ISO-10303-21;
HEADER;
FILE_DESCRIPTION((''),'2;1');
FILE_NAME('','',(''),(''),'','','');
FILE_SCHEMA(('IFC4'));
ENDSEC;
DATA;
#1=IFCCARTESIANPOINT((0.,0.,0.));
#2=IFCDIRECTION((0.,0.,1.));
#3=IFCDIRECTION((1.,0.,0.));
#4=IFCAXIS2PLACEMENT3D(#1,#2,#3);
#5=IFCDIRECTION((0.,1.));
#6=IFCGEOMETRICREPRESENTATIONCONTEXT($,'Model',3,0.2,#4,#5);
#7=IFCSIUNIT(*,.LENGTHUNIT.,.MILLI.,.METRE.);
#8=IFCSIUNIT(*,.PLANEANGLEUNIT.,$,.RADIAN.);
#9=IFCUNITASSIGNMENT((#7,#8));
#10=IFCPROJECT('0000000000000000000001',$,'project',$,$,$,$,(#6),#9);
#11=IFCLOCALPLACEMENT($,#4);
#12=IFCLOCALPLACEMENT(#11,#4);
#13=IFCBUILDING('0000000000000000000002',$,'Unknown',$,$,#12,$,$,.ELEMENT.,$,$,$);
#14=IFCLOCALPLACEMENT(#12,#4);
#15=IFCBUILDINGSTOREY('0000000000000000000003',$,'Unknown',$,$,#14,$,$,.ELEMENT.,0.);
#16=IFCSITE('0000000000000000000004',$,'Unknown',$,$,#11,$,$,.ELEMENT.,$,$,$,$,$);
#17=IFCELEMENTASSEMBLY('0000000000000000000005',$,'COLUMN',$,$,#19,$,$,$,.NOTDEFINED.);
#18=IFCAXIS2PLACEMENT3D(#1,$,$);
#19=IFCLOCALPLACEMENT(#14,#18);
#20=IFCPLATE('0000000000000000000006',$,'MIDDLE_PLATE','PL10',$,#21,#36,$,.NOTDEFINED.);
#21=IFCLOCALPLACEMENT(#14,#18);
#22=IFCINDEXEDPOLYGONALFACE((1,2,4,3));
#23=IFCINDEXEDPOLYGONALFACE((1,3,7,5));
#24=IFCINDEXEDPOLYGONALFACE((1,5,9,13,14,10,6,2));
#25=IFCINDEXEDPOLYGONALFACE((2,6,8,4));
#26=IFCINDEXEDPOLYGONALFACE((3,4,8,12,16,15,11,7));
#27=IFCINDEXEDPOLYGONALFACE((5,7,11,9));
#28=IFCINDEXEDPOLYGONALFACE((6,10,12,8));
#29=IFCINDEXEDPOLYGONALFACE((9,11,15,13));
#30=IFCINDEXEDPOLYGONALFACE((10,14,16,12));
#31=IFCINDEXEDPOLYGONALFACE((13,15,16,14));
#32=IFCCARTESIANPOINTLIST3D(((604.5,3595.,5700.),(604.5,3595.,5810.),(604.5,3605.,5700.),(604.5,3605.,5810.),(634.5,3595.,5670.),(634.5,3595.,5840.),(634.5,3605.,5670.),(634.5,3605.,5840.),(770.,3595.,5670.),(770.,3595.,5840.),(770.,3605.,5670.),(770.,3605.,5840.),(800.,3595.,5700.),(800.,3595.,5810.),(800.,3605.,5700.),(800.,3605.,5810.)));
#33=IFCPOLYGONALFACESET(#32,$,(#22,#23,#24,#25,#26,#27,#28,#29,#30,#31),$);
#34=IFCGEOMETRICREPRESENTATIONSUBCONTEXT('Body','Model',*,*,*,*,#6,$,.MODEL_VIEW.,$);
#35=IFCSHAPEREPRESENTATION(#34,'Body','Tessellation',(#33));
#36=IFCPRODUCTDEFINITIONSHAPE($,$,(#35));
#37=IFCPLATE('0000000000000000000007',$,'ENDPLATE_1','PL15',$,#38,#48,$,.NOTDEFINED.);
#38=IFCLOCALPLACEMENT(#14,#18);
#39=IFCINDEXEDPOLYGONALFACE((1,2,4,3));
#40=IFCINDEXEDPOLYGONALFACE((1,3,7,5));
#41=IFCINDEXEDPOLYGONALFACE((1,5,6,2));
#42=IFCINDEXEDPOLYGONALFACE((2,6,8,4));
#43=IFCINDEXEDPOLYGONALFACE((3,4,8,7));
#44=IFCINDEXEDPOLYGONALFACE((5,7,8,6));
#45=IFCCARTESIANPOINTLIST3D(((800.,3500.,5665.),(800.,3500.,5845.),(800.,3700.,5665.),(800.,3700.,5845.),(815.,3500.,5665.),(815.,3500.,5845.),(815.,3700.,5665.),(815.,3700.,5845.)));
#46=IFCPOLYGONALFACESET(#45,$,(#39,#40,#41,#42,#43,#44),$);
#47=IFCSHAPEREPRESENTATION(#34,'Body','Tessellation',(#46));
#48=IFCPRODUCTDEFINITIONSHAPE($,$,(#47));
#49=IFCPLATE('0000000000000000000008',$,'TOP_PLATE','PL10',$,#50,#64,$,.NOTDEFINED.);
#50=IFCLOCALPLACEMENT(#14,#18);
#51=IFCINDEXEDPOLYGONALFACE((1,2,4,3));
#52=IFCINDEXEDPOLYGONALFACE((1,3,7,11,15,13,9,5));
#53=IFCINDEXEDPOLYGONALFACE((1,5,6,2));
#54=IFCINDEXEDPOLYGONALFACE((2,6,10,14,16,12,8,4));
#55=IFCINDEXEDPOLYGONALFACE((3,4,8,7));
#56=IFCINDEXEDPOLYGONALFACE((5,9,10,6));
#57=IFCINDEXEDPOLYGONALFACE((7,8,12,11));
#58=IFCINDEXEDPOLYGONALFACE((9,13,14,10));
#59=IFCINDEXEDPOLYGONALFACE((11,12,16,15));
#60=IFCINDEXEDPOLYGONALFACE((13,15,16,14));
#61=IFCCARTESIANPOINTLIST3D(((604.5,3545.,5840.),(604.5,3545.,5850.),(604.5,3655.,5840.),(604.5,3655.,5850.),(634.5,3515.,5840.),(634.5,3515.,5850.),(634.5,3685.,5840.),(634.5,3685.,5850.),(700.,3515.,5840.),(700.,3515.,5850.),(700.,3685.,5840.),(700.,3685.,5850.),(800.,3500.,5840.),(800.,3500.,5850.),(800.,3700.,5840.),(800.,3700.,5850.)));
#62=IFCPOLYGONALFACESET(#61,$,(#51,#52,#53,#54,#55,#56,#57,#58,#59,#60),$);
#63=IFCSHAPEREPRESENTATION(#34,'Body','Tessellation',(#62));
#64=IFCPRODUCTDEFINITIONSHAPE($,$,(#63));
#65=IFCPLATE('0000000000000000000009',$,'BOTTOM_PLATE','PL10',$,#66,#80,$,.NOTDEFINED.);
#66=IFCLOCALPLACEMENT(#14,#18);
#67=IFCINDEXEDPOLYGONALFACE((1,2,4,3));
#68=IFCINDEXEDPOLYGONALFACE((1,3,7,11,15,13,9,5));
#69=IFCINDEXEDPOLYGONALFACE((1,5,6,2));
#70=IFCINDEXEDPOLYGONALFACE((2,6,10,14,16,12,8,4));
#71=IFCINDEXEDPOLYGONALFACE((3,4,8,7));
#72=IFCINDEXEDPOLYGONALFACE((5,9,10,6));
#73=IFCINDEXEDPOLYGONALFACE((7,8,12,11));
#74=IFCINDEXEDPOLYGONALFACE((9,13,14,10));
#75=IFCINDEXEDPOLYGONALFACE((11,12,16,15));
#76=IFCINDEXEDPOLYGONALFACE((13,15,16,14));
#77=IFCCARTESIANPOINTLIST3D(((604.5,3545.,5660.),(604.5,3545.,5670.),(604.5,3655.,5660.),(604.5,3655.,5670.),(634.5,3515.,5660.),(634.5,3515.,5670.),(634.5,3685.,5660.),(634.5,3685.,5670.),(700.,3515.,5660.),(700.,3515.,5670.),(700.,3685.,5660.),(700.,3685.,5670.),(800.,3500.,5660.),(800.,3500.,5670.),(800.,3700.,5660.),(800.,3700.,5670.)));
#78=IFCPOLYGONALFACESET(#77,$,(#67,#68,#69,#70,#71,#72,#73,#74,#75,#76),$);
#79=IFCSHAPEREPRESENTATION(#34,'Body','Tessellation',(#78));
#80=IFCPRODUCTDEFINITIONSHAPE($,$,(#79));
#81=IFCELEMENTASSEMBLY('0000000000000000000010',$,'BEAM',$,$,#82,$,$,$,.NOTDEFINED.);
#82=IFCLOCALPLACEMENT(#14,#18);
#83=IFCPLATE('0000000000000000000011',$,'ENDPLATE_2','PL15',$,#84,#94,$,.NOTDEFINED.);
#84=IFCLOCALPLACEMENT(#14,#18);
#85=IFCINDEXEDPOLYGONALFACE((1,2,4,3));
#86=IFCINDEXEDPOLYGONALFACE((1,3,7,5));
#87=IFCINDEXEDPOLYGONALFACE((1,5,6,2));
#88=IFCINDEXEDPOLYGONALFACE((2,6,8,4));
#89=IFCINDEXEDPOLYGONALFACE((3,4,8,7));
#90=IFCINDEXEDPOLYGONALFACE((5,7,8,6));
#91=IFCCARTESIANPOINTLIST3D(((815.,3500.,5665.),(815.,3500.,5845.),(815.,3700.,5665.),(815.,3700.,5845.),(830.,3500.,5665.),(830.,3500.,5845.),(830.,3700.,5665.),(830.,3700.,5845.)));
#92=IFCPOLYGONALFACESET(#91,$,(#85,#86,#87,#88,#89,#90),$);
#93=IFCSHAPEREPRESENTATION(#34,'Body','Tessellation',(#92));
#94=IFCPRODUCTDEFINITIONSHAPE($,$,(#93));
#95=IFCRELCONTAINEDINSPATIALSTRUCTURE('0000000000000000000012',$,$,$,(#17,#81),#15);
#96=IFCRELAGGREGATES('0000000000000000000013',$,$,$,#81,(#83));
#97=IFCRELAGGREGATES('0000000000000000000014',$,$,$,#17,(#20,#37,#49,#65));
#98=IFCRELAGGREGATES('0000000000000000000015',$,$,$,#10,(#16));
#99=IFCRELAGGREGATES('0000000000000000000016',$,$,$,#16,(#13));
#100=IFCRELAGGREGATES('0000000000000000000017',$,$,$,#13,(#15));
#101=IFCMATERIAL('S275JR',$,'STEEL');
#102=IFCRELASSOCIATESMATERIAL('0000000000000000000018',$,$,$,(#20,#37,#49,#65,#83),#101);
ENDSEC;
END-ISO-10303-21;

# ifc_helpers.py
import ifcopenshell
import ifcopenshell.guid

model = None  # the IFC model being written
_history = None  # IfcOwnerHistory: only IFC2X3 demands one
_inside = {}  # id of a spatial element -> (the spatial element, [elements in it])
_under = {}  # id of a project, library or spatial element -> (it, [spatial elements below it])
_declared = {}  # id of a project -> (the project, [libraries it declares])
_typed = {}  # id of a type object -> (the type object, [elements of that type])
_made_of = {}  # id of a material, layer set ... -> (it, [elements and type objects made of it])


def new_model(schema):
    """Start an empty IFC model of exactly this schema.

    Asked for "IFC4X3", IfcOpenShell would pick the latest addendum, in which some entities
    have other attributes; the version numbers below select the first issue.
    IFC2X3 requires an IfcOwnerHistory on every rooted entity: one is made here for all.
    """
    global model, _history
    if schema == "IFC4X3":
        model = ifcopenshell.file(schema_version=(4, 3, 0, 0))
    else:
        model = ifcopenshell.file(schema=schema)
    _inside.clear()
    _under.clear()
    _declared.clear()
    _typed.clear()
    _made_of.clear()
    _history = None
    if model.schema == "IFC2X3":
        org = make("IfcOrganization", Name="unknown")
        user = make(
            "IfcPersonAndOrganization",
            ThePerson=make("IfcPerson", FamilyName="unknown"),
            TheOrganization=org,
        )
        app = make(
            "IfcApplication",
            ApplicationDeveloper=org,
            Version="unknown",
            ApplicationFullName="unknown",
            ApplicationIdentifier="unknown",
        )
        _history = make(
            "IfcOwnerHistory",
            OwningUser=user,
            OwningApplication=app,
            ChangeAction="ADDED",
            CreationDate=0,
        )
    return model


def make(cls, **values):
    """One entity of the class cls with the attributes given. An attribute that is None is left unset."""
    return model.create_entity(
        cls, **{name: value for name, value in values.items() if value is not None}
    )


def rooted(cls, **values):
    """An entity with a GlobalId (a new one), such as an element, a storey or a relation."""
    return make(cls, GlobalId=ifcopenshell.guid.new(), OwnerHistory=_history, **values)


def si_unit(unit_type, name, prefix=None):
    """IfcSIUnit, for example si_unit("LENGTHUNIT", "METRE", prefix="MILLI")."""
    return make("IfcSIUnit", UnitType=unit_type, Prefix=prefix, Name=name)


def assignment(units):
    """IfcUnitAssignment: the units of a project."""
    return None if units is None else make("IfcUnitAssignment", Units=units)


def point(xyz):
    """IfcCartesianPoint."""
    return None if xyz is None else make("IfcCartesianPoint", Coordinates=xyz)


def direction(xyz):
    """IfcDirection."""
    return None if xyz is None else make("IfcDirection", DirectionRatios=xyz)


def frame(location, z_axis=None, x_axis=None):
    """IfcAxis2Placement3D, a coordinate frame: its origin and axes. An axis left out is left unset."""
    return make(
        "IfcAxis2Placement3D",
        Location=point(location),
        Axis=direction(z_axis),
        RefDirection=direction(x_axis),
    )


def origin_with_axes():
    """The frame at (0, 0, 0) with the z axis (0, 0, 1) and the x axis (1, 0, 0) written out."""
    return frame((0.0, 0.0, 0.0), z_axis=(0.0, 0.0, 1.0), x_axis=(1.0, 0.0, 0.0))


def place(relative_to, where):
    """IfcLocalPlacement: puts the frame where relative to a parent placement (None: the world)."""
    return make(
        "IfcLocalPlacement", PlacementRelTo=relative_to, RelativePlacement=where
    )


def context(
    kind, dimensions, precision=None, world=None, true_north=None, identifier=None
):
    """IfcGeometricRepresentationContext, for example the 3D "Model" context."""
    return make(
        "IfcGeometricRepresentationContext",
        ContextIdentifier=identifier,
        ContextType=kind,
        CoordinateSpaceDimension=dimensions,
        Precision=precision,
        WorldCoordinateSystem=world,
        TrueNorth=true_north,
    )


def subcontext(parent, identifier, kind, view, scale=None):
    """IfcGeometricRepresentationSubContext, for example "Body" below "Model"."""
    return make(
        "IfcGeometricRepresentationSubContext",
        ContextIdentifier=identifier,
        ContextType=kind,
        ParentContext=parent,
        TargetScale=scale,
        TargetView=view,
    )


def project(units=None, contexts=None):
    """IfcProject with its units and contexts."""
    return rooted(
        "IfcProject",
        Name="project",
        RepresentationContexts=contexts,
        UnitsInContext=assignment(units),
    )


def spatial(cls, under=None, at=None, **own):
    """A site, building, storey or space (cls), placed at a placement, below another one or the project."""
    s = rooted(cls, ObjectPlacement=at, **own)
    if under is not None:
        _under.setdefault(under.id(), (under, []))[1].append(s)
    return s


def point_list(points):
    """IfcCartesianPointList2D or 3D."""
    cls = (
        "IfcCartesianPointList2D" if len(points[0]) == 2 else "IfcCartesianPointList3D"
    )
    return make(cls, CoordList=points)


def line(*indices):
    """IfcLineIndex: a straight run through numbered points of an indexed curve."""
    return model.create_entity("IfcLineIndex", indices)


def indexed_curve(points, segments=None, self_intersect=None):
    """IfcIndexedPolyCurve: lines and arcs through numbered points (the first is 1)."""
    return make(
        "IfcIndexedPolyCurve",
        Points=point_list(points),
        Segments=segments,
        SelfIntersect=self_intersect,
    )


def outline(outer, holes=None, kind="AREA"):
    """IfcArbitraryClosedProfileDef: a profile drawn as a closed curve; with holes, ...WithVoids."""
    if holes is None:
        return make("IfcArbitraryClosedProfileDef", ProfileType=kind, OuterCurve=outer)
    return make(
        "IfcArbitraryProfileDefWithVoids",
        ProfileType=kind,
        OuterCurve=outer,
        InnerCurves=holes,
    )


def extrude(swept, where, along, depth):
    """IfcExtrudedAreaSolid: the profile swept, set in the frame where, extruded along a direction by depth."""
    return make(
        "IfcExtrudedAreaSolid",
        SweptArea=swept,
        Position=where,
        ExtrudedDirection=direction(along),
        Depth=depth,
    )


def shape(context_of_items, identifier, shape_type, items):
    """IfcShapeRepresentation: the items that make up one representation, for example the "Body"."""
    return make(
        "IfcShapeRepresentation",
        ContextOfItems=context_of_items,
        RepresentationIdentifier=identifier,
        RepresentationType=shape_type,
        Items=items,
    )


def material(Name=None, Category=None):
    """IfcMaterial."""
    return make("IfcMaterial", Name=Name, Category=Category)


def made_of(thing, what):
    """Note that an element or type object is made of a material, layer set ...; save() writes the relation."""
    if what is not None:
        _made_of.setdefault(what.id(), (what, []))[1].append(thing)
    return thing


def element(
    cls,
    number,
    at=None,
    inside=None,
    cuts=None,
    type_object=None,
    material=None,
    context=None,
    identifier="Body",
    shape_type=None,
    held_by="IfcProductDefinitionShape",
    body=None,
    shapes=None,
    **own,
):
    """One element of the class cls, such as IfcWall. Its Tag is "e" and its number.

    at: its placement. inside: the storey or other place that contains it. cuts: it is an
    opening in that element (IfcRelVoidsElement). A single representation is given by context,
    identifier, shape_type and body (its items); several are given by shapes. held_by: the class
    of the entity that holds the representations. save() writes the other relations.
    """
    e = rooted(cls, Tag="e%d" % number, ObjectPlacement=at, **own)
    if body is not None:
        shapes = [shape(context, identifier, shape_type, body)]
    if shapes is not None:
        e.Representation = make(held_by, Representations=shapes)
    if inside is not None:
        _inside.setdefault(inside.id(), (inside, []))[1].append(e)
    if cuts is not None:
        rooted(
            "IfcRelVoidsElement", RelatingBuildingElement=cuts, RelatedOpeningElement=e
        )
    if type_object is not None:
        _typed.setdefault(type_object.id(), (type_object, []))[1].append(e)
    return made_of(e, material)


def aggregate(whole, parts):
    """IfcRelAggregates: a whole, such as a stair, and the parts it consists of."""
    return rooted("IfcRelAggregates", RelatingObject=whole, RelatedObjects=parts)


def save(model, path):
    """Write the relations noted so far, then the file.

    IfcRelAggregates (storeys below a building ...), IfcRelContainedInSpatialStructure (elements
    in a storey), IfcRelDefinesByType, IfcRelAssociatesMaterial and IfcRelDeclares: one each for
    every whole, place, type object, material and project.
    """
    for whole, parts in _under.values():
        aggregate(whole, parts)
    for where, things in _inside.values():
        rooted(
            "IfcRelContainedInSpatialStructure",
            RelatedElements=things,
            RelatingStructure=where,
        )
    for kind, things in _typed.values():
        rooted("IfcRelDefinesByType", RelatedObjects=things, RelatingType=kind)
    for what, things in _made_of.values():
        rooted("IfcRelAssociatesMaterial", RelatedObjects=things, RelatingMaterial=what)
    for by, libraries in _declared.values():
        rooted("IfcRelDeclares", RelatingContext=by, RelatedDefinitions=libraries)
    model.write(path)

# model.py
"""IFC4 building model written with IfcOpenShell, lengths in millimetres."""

from ifc_helpers import new_model, si_unit, direction, frame, origin_with_axes, place, context, subcontext, project, spatial, line, indexed_curve, outline, extrude, material, element, aggregate, save


model = new_model("IFC4")

# Units and contexts
model_context = context("Model", 3, precision=0.2, world=origin_with_axes(), true_north=direction((0.0, 1.0)))
body_context = subcontext(model_context, "Body", "Model", "MODEL_VIEW")
ifc_project = project(units=[si_unit("LENGTHUNIT", "METRE", prefix="MILLI"), si_unit("PLANEANGLEUNIT", "RADIAN")], contexts=[model_context])

# Site, building, storey
site_placement = place(None, origin_with_axes())
site = spatial("IfcSite", under=ifc_project, at=site_placement, Name="Unknown", CompositionType="ELEMENT")
building_placement = place(site_placement, origin_with_axes())
building = spatial("IfcBuilding", under=site, at=building_placement, Name="Unknown", CompositionType="ELEMENT")
storey_placement = place(building_placement, origin_with_axes())
storey = spatial("IfcBuildingStorey", under=building, at=storey_placement, Name="Unknown", CompositionType="ELEMENT", Elevation=0.0)

# Shared definitions
ifc_material_1 = material(Name="S275JR", Category="STEEL")

# Element assemblies, plates
assembly_1_placement = place(storey_placement, frame((600.0, 3600.0, 200.0), z_axis=(-1.0, 0.0, 0.0), x_axis=(0.0, 0.0, 1.0)))
assembly_1 = element("IfcElementAssembly", 1, at=assembly_1_placement, inside=storey, Name="COLUMN", PredefinedType="NOTDEFINED")
plate_1_placement = place(assembly_1_placement, frame((5640.0, 0.0, -200.0), z_axis=(0.0, -1.0, 0.000002), x_axis=(0.0, 0.0, 1.0)))
plate_1 = element("IfcPlate", 2, at=plate_1_placement, material=ifc_material_1, Name="MIDDLE_PLATE", Description="PL10", PredefinedType="NOTDEFINED", context=body_context, shape_type="SolidModel", body=[
    extrude(outline(indexed_curve([(0.0, 30.0), (30.0, 0.0), (165.5, 0.0), (195.5, 30.0), (195.5, 140.0), (165.5, 170.0), (30.0, 170.0), (0.0, 140.0)], segments=[line(1, 2, 3, 4, 5, 6, 7, 8, 1)])), frame((0.0, 0.0, 5.0), z_axis=(0.0, 0.0, 1.0), x_axis=(1.0, 0.0, 0.0)), (0.0, -0.000002, -1.0), 10.0),
])
plate_2_placement = place(assembly_1_placement, frame((5465.0, 100.0, -207.5), z_axis=(0.0, -0.000002, -1.0), x_axis=(1.0, 0.0, 0.0)))
plate_2 = element("IfcPlate", 3, at=plate_2_placement, material=ifc_material_1, Name="ENDPLATE_1", Description="PL15", PredefinedType="NOTDEFINED", context=body_context, shape_type="SolidModel", body=[
    extrude(outline(indexed_curve([(0.0, 0.0), (180.0, 0.0), (180.0, 200.0), (0.0, 200.0)], segments=[line(1, 2, 3, 4, 1)])), frame((0.0, 0.0, 7.5), z_axis=(0.0, 0.0, 1.0), x_axis=(1.0, 0.0, 0.0)), (0.0, -0.000002, -1.0), 15.0),
])
plate_3_placement = place(assembly_1_placement, frame((5645.0, 85.0, -100.0), z_axis=(1.0, 0.0, 0.0), x_axis=(0.0, 0.0, 1.0)))
plate_3 = element("IfcPlate", 4, at=plate_3_placement, material=ifc_material_1, Name="TOP_PLATE", Description="PL10", PredefinedType="NOTDEFINED", context=body_context, shape_type="SolidModel", body=[
    extrude(outline(indexed_curve([(0.0, 0.0), (65.5, 0.0), (95.5, 30.0), (95.5, 140.0), (65.5, 170.0), (0.0, 170.0), (-100.0, 185.0), (-100.0, -15.0)], segments=[line(1, 2, 3, 4, 5, 6, 7, 8, 1)])), frame((0.0, 0.0, 5.0), z_axis=(0.0, 0.0, 1.0), x_axis=(1.0, 0.0, 0.0)), (0.0, -0.000002, -1.0), 10.0),
])
plate_4_placement = place(assembly_1_placement, frame((5465.0, 85.0, -4.5), z_axis=(1.0, 0.0, 0.0), x_axis=(0.0, -1.0, 0.000002)))
plate_4 = element("IfcPlate", 5, at=plate_4_placement, material=ifc_material_1, Name="BOTTOM_PLATE", Description="PL10", PredefinedType="NOTDEFINED", context=body_context, shape_type="SolidModel", body=[
    extrude(outline(indexed_curve([(0.0, 30.0), (30.0, 0.0), (140.0, 0.0), (170.0, 30.0), (170.0, 95.5), (185.0, 195.5), (-15.0, 195.5), (0.0, 95.5)], segments=[line(1, 2, 3, 4, 5, 6, 7, 8, 1)])), frame((0.0, 0.0, 5.0), z_axis=(0.0, 0.0, 1.0), x_axis=(1.0, 0.0, 0.0)), (0.0, -0.000002, -1.0), 10.0),
])
assembly_2_placement = place(storey_placement, frame((600.0, 3600.0, 5755.0), z_axis=(-0.000002, -1.0, 0.0), x_axis=(1.0, 0.0, 0.0)))
assembly_2 = element("IfcElementAssembly", 6, at=assembly_2_placement, inside=storey, Name="BEAM", PredefinedType="NOTDEFINED")
plate_5_placement = place(assembly_2_placement, frame((222.5, -90.0, -100.0), z_axis=(1.0, 0.0, 0.0), x_axis=(0.0, 1.0, 0.0)))
plate_5 = element("IfcPlate", 7, at=plate_5_placement, material=ifc_material_1, Name="ENDPLATE_2", Description="PL15", PredefinedType="NOTDEFINED", context=body_context, shape_type="SolidModel", body=[
    extrude(outline(indexed_curve([(0.0, 0.0), (180.0, 0.0), (180.0, 200.0), (0.0, 200.0)], segments=[line(1, 2, 3, 4, 1)])), frame((0.0, 0.0, 7.5), z_axis=(0.0, 0.0, 1.0), x_axis=(1.0, 0.0, 0.0)), (0.0, -0.000002, -1.0), 15.0),
])
aggregate(assembly_2, [plate_5])

aggregate(assembly_1, [plate_1, plate_2, plate_3, plate_4])

save(model, "model.ifc")
